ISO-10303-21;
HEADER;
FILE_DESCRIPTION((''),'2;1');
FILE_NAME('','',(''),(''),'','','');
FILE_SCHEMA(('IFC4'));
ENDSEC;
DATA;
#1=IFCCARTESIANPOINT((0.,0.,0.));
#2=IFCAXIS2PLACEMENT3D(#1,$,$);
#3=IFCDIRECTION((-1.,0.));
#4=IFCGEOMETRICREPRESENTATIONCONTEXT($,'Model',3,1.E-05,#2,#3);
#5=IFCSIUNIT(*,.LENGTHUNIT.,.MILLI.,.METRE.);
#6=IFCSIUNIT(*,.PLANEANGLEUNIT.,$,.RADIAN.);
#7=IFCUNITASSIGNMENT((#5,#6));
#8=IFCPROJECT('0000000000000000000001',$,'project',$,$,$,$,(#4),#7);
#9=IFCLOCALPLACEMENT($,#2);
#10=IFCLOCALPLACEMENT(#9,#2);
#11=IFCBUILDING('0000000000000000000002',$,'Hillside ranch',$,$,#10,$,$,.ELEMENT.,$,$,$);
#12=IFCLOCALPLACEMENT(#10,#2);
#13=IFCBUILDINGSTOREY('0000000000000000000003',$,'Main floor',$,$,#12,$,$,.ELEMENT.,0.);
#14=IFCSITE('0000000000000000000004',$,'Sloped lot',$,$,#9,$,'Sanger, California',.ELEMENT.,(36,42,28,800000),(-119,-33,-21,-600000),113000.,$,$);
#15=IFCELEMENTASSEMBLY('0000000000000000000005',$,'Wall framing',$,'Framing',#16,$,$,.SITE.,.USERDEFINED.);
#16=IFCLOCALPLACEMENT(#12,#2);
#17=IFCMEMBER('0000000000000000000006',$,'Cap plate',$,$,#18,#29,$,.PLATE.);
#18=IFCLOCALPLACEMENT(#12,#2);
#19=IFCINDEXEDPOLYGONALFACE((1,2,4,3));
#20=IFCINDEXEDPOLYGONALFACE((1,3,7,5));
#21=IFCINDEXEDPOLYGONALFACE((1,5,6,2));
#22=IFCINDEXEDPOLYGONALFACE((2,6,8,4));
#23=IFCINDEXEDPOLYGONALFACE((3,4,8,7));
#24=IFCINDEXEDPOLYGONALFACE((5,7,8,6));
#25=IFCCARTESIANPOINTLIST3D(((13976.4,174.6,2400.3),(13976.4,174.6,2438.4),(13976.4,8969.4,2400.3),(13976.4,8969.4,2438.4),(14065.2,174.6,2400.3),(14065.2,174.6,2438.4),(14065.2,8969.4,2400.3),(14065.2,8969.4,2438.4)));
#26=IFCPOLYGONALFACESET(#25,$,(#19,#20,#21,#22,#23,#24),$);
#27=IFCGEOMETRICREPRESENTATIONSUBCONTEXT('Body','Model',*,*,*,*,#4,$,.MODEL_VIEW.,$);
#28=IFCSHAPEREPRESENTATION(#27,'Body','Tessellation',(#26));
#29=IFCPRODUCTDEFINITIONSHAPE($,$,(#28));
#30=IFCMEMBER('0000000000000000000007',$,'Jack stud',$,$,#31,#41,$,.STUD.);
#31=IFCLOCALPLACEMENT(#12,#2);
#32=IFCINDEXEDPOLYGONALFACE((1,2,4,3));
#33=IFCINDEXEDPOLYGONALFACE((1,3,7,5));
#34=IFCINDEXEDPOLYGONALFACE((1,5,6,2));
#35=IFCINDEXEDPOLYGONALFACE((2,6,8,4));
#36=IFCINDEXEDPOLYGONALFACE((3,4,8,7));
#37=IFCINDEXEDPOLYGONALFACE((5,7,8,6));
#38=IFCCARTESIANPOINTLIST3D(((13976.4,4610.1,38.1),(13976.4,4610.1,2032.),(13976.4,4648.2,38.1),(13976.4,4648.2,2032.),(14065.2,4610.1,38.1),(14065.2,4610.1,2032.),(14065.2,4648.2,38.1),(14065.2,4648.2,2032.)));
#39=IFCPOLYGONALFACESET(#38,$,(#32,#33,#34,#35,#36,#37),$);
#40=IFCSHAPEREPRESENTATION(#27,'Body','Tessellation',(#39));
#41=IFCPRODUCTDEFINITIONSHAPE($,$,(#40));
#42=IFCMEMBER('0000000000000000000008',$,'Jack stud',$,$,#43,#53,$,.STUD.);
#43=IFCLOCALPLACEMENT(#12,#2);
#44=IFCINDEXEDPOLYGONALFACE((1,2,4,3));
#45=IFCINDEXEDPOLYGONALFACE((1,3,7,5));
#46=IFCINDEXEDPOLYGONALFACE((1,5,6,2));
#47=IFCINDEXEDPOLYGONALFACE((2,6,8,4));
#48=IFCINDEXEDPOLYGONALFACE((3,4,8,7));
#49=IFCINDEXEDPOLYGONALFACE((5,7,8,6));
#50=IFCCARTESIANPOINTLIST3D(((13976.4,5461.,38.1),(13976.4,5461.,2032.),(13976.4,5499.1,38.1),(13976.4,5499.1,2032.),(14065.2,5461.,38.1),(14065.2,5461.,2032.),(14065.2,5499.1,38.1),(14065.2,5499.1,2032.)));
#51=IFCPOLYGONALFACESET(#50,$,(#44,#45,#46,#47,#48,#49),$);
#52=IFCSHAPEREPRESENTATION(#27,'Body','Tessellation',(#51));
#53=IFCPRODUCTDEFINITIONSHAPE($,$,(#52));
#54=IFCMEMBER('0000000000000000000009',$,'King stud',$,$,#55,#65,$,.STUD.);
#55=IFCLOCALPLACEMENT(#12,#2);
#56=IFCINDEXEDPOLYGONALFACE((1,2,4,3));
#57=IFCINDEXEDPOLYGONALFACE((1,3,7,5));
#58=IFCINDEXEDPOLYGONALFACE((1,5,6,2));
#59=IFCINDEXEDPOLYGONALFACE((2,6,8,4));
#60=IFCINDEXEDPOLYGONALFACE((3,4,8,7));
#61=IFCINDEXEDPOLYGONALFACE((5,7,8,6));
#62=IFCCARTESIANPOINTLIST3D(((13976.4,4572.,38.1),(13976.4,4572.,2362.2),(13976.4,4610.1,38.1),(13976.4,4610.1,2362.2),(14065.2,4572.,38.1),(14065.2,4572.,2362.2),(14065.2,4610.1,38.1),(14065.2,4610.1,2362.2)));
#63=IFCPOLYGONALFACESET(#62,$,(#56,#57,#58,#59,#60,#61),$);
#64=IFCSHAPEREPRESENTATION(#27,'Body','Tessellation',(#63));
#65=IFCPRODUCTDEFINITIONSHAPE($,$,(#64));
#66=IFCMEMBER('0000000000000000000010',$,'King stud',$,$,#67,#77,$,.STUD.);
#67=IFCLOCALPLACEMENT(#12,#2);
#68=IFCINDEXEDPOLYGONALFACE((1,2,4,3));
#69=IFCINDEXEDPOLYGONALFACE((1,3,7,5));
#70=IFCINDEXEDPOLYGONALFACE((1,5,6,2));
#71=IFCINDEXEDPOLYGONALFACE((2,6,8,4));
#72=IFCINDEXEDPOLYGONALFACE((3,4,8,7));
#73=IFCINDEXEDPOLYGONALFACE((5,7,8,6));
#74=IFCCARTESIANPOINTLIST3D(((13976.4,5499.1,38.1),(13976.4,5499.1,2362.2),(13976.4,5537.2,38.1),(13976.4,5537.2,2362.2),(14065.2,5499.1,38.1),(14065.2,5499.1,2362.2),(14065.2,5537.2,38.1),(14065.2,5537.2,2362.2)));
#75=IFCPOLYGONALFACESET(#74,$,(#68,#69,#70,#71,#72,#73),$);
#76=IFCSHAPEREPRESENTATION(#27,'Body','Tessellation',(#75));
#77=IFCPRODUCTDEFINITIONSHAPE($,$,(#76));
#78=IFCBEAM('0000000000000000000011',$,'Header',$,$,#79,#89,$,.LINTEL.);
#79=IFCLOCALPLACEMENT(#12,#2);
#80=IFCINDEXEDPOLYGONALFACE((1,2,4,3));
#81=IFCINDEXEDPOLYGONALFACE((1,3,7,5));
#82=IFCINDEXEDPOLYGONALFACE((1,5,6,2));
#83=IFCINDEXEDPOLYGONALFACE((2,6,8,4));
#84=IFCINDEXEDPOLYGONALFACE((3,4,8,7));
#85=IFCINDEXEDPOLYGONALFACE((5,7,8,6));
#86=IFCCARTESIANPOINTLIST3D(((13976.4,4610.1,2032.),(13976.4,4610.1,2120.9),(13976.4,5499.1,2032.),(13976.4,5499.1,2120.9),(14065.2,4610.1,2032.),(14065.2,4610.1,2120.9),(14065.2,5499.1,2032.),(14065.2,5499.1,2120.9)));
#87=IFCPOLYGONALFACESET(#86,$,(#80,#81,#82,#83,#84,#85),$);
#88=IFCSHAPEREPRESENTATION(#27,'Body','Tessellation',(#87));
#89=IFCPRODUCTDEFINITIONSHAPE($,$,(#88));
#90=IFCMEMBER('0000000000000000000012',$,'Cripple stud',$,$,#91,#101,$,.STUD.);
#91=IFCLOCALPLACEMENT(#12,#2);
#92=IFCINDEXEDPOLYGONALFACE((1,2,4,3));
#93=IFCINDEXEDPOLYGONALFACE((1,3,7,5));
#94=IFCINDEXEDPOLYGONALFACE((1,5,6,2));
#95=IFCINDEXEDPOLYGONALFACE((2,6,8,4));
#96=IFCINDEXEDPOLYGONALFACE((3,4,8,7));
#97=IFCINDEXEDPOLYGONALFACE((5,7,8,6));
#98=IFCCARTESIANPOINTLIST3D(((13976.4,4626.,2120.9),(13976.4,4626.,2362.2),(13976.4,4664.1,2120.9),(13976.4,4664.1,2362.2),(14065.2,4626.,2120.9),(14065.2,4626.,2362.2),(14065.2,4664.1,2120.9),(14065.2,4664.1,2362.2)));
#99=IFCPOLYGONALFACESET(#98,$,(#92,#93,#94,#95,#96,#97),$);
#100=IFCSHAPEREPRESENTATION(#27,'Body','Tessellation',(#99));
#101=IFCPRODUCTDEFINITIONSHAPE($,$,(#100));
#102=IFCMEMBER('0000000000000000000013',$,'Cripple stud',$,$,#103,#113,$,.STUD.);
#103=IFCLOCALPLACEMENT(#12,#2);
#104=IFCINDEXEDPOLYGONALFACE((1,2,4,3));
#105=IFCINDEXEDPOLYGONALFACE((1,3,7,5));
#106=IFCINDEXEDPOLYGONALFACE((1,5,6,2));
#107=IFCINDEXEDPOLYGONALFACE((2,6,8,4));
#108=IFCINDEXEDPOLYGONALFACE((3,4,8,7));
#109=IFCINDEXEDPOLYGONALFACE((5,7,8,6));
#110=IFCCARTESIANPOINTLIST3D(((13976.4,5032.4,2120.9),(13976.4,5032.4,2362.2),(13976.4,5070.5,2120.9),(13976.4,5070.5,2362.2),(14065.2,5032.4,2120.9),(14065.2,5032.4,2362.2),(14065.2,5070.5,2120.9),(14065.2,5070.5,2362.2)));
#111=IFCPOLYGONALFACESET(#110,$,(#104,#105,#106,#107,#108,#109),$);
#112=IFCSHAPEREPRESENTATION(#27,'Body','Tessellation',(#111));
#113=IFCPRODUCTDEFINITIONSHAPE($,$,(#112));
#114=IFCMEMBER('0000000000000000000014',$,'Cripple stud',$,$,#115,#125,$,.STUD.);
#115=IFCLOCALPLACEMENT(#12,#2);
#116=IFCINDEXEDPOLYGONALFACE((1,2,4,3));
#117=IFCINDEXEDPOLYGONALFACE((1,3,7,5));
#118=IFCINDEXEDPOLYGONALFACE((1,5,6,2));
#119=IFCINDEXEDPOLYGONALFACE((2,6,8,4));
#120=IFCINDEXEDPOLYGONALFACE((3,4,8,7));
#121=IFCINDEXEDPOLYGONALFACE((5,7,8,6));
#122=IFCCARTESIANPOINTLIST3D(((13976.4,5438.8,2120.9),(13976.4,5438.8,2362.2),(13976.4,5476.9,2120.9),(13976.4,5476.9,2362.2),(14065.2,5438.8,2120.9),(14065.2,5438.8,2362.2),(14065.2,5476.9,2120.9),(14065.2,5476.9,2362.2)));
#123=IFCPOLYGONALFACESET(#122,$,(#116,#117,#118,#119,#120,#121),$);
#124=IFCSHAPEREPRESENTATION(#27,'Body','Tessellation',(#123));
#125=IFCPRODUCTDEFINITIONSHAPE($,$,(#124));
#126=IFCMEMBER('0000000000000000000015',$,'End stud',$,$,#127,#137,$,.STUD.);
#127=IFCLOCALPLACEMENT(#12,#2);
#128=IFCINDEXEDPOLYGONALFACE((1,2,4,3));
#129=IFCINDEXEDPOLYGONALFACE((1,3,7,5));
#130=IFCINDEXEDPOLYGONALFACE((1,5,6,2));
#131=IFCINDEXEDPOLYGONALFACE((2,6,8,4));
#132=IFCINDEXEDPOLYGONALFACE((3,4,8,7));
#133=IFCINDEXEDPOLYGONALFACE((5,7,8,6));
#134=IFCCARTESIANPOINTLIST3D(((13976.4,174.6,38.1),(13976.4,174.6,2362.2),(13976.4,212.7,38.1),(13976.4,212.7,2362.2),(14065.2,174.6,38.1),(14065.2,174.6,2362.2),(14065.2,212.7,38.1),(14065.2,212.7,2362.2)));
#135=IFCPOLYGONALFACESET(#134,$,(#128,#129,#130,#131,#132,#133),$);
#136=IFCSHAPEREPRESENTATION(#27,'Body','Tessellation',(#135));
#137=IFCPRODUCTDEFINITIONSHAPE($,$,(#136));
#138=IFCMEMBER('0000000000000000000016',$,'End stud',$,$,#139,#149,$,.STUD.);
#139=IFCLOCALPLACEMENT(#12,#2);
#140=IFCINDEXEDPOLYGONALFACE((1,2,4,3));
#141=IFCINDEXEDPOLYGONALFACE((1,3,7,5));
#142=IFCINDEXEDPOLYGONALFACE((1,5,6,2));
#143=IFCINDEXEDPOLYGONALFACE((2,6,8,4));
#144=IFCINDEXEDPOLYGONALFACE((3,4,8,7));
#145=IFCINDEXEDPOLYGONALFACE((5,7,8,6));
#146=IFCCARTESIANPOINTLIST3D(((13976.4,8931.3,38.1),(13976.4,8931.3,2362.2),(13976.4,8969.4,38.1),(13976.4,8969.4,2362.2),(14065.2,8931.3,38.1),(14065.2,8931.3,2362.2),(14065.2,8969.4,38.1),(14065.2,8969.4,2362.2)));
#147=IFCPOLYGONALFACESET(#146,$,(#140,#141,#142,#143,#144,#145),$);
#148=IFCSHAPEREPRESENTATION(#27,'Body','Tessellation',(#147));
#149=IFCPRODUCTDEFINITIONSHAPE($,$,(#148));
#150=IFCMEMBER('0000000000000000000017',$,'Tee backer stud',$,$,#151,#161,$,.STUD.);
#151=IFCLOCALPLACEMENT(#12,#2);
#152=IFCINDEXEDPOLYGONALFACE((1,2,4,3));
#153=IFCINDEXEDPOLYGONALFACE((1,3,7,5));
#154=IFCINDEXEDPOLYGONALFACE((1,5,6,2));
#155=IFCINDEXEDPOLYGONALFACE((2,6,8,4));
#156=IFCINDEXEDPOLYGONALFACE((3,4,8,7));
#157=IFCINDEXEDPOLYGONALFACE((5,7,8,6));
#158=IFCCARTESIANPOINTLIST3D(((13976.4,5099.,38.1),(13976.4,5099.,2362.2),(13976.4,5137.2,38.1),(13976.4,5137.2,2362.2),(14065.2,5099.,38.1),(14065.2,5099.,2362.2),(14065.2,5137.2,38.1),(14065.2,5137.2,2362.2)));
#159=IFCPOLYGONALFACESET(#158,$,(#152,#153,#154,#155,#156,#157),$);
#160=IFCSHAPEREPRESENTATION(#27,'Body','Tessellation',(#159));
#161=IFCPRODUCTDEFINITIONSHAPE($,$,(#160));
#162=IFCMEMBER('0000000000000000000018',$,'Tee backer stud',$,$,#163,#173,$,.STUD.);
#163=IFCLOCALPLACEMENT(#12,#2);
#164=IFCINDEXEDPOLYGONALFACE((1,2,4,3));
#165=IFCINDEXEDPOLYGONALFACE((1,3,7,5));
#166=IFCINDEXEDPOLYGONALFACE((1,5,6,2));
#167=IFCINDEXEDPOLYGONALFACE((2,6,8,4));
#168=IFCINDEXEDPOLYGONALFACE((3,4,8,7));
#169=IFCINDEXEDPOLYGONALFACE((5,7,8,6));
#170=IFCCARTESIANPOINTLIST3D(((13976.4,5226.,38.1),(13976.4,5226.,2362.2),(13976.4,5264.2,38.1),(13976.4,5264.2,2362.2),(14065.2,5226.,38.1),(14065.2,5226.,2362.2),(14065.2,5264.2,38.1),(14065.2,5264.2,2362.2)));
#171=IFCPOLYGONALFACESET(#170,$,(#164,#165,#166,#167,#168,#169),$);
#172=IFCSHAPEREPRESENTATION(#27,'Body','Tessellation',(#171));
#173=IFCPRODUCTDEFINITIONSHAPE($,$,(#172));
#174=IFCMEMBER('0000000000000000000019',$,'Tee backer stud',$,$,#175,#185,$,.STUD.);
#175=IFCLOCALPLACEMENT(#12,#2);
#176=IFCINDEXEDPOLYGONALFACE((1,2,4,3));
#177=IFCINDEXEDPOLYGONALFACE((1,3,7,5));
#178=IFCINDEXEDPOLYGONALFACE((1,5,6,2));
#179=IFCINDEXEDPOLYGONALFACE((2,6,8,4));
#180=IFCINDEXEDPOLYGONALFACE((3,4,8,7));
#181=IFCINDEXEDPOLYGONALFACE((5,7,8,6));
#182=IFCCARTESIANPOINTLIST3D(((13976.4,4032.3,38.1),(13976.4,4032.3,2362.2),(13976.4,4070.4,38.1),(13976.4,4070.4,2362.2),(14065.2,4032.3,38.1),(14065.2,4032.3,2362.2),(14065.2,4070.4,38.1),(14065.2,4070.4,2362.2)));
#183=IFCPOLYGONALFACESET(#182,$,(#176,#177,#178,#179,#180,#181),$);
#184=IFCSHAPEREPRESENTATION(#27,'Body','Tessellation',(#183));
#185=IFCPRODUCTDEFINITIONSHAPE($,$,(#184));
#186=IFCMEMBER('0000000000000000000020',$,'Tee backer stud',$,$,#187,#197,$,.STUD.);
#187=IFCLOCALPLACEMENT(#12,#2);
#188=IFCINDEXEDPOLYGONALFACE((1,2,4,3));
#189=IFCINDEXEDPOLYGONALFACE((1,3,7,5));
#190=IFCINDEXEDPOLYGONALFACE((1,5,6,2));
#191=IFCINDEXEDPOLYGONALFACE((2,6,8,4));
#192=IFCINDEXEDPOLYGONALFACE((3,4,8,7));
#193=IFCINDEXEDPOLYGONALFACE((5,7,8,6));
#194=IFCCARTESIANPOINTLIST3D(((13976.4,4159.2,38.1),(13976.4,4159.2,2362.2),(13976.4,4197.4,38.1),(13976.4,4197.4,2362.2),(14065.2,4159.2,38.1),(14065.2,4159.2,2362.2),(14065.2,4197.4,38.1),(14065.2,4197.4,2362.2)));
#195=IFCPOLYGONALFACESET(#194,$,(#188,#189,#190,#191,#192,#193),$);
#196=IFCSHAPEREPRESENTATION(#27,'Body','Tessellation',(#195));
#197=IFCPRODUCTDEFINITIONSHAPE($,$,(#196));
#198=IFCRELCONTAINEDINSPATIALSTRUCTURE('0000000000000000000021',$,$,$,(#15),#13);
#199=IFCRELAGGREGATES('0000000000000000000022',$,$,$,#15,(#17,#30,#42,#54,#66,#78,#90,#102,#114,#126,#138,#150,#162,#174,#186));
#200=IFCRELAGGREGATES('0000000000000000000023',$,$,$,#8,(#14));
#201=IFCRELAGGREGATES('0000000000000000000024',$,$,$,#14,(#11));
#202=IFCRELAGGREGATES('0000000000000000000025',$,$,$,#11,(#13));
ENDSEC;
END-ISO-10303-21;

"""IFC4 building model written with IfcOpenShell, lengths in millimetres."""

from ifc_helpers import new_model, si_unit, direction, frame, origin, origin_with_axes, place, context, subcontext, project, spatial, polyline, outline, extrude, element, aggregate, save


model = new_model("IFC4")

# Units and contexts
model_context = context("Model", 3, precision=1e-05, world=origin(), true_north=direction((-1.0, 0.0)))
body_context = subcontext(model_context, "Body", "Model", "MODEL_VIEW")
ifc_project = project(units=[si_unit("LENGTHUNIT", "METRE", prefix="MILLI"), si_unit("PLANEANGLEUNIT", "RADIAN")], contexts=[model_context])

# Site, building, storey
site_placement = place(None, origin())
site = spatial("IfcSite", under=ifc_project, at=site_placement, Name="Sloped lot", LongName="Sanger, California", CompositionType="ELEMENT", RefLatitude=(36, 42, 28, 800000), RefLongitude=(-119, -33, -21, -600000), RefElevation=113000.0)
building_placement = place(site_placement, origin())
building = spatial("IfcBuilding", under=site, at=building_placement, Name="Hillside ranch", CompositionType="ELEMENT")
storey_placement = place(building_placement, origin())
storey = spatial("IfcBuildingStorey", under=building, at=storey_placement, Name="Main floor", CompositionType="ELEMENT", Elevation=0.0)

# Element assembly, members, beam
assembly_placement = place(storey_placement, origin_with_axes())
assembly = element("IfcElementAssembly", 1, at=assembly_placement, inside=storey, Name="Wall framing", ObjectType="Framing", AssemblyPlace="SITE", PredefinedType="USERDEFINED")
member_1_placement = place(storey_placement, origin_with_axes())
member_1 = element("IfcMember", 2, at=member_1_placement, Name="Cap plate", PredefinedType="PLATE", context=body_context, shape_type="SweptSolid", body=[
    extrude(outline(polyline([(0.0, 0.0), (8794.8, 0.0), (8794.8, 88.9), (0.0, 88.9), (0.0, 0.0)])), frame((14065.2, 174.6, 2400.3), z_axis=(0.0, 0.0, 1.0), x_axis=(0.0, 1.0, 0.0)), (0.0, 0.0, 1.0), 38.1),
])
member_2_placement = place(storey_placement, origin_with_axes())
member_2 = element("IfcMember", 3, at=member_2_placement, Name="Jack stud", PredefinedType="STUD", context=body_context, shape_type="SweptSolid", body=[
    extrude(outline(polyline([(0.0, 0.0), (38.1, 0.0), (38.1, 88.9), (0.0, 88.9), (0.0, 0.0)])), frame((14065.2, 4610.1, 38.1), z_axis=(0.0, 0.0, 1.0), x_axis=(0.0, 1.0, 0.0)), (0.0, 0.0, 1.0), 1993.9),
])
member_3_placement = place(storey_placement, origin_with_axes())
member_3 = element("IfcMember", 4, at=member_3_placement, Name="Jack stud", PredefinedType="STUD", context=body_context, shape_type="SweptSolid", body=[
    extrude(outline(polyline([(0.0, 0.0), (38.1, 0.0), (38.1, 88.9), (0.0, 88.9), (0.0, 0.0)])), frame((14065.2, 5461.0, 38.1), z_axis=(0.0, 0.0, 1.0), x_axis=(0.0, 1.0, 0.0)), (0.0, 0.0, 1.0), 1993.9),
])
member_4_placement = place(storey_placement, origin_with_axes())
member_4 = element("IfcMember", 5, at=member_4_placement, Name="King stud", PredefinedType="STUD", context=body_context, shape_type="SweptSolid", body=[
    extrude(outline(polyline([(0.0, 0.0), (38.1, 0.0), (38.1, 88.9), (0.0, 88.9), (0.0, 0.0)])), frame((14065.2, 4572.0, 38.1), z_axis=(0.0, 0.0, 1.0), x_axis=(0.0, 1.0, 0.0)), (0.0, 0.0, 1.0), 2324.1),
])
member_5_placement = place(storey_placement, origin_with_axes())
member_5 = element("IfcMember", 6, at=member_5_placement, Name="King stud", PredefinedType="STUD", context=body_context, shape_type="SweptSolid", body=[
    extrude(outline(polyline([(0.0, 0.0), (38.1, 0.0), (38.1, 88.9), (0.0, 88.9), (0.0, 0.0)])), frame((14065.2, 5499.1, 38.1), z_axis=(0.0, 0.0, 1.0), x_axis=(0.0, 1.0, 0.0)), (0.0, 0.0, 1.0), 2324.1),
])
beam_placement = place(storey_placement, origin_with_axes())
beam = element("IfcBeam", 7, at=beam_placement, Name="Header", PredefinedType="LINTEL", context=body_context, shape_type="SweptSolid", body=[
    extrude(outline(polyline([(0.0, 0.0), (889.0, 0.0), (889.0, 88.9), (0.0, 88.9), (0.0, 0.0)])), frame((14065.2, 4610.1, 2032.0), z_axis=(0.0, 0.0, 1.0), x_axis=(0.0, 1.0, 0.0)), (0.0, 0.0, 1.0), 88.9),
])
member_6_placement = place(storey_placement, origin_with_axes())
member_6 = element("IfcMember", 8, at=member_6_placement, Name="Cripple stud", PredefinedType="STUD", context=body_context, shape_type="SweptSolid", body=[
    extrude(outline(polyline([(0.0, 0.0), (38.1, 0.0), (38.1, 88.9), (0.0, 88.9), (0.0, 0.0)])), frame((14065.2, 4626.0, 2120.9), z_axis=(0.0, 0.0, 1.0), x_axis=(0.0, 1.0, 0.0)), (0.0, 0.0, 1.0), 241.3),
])
member_7_placement = place(storey_placement, origin_with_axes())
member_7 = element("IfcMember", 9, at=member_7_placement, Name="Cripple stud", PredefinedType="STUD", context=body_context, shape_type="SweptSolid", body=[
    extrude(outline(polyline([(0.0, 0.0), (38.1, 0.0), (38.1, 88.9), (0.0, 88.9), (0.0, 0.0)])), frame((14065.2, 5032.4, 2120.9), z_axis=(0.0, 0.0, 1.0), x_axis=(0.0, 1.0, 0.0)), (0.0, 0.0, 1.0), 241.3),
])
member_8_placement = place(storey_placement, origin_with_axes())
member_8 = element("IfcMember", 10, at=member_8_placement, Name="Cripple stud", PredefinedType="STUD", context=body_context, shape_type="SweptSolid", body=[
    extrude(outline(polyline([(0.0, 0.0), (38.1, 0.0), (38.1, 88.9), (0.0, 88.9), (0.0, 0.0)])), frame((14065.2, 5438.8, 2120.9), z_axis=(0.0, 0.0, 1.0), x_axis=(0.0, 1.0, 0.0)), (0.0, 0.0, 1.0), 241.3),
])
member_9_placement = place(storey_placement, origin_with_axes())
member_9 = element("IfcMember", 11, at=member_9_placement, Name="End stud", PredefinedType="STUD", context=body_context, shape_type="SweptSolid", body=[
    extrude(outline(polyline([(0.0, 0.0), (38.1, 0.0), (38.1, 88.9), (0.0, 88.9), (0.0, 0.0)])), frame((14065.2, 174.6, 38.1), z_axis=(0.0, 0.0, 1.0), x_axis=(0.0, 1.0, 0.0)), (0.0, 0.0, 1.0), 2324.1),
])
member_10_placement = place(storey_placement, origin_with_axes())
member_10 = element("IfcMember", 12, at=member_10_placement, Name="End stud", PredefinedType="STUD", context=body_context, shape_type="SweptSolid", body=[
    extrude(outline(polyline([(0.0, 0.0), (38.1, 0.0), (38.1, 88.9), (0.0, 88.9), (0.0, 0.0)])), frame((14065.2, 8931.3, 38.1), z_axis=(0.0, 0.0, 1.0), x_axis=(0.0, 1.0, 0.0)), (0.0, 0.0, 1.0), 2324.1),
])
member_11_placement = place(storey_placement, origin_with_axes())
member_11 = element("IfcMember", 13, at=member_11_placement, Name="Tee backer stud", PredefinedType="STUD", context=body_context, shape_type="SweptSolid", body=[
    extrude(outline(polyline([(0.0, 0.0), (38.1, 0.0), (38.1, 88.9), (0.0, 88.9), (0.0, 0.0)])), frame((14065.2, 5099.1, 38.1), z_axis=(0.0, 0.0, 1.0), x_axis=(0.0, 1.0, 0.0)), (0.0, 0.0, 1.0), 2324.1),
])
member_12_placement = place(storey_placement, origin_with_axes())
member_12 = element("IfcMember", 14, at=member_12_placement, Name="Tee backer stud", PredefinedType="STUD", context=body_context, shape_type="SweptSolid", body=[
    extrude(outline(polyline([(0.0, 0.0), (38.1, 0.0), (38.1, 88.9), (0.0, 88.9), (0.0, 0.0)])), frame((14065.2, 5226.1, 38.1), z_axis=(0.0, 0.0, 1.0), x_axis=(0.0, 1.0, 0.0)), (0.0, 0.0, 1.0), 2324.1),
])
member_13_placement = place(storey_placement, origin_with_axes())
member_13 = element("IfcMember", 15, at=member_13_placement, Name="Tee backer stud", PredefinedType="STUD", context=body_context, shape_type="SweptSolid", body=[
    extrude(outline(polyline([(0.0, 0.0), (38.1, 0.0), (38.1, 88.9), (0.0, 88.9), (0.0, 0.0)])), frame((14065.2, 4032.2, 38.1), z_axis=(0.0, 0.0, 1.0), x_axis=(0.0, 1.0, 0.0)), (0.0, 0.0, 1.0), 2324.1),
])
member_14_placement = place(storey_placement, origin_with_axes())
member_14 = element("IfcMember", 16, at=member_14_placement, Name="Tee backer stud", PredefinedType="STUD", context=body_context, shape_type="SweptSolid", body=[
    extrude(outline(polyline([(0.0, 0.0), (38.1, 0.0), (38.1, 88.9), (0.0, 88.9), (0.0, 0.0)])), frame((14065.2, 4159.2, 38.1), z_axis=(0.0, 0.0, 1.0), x_axis=(0.0, 1.0, 0.0)), (0.0, 0.0, 1.0), 2324.1),
])
aggregate(assembly, [member_1, member_2, member_3, member_4, member_5, beam, member_6, member_7, member_8, member_9, member_10, member_11, member_12, member_13, member_14])

save(model, "model.ifc")
